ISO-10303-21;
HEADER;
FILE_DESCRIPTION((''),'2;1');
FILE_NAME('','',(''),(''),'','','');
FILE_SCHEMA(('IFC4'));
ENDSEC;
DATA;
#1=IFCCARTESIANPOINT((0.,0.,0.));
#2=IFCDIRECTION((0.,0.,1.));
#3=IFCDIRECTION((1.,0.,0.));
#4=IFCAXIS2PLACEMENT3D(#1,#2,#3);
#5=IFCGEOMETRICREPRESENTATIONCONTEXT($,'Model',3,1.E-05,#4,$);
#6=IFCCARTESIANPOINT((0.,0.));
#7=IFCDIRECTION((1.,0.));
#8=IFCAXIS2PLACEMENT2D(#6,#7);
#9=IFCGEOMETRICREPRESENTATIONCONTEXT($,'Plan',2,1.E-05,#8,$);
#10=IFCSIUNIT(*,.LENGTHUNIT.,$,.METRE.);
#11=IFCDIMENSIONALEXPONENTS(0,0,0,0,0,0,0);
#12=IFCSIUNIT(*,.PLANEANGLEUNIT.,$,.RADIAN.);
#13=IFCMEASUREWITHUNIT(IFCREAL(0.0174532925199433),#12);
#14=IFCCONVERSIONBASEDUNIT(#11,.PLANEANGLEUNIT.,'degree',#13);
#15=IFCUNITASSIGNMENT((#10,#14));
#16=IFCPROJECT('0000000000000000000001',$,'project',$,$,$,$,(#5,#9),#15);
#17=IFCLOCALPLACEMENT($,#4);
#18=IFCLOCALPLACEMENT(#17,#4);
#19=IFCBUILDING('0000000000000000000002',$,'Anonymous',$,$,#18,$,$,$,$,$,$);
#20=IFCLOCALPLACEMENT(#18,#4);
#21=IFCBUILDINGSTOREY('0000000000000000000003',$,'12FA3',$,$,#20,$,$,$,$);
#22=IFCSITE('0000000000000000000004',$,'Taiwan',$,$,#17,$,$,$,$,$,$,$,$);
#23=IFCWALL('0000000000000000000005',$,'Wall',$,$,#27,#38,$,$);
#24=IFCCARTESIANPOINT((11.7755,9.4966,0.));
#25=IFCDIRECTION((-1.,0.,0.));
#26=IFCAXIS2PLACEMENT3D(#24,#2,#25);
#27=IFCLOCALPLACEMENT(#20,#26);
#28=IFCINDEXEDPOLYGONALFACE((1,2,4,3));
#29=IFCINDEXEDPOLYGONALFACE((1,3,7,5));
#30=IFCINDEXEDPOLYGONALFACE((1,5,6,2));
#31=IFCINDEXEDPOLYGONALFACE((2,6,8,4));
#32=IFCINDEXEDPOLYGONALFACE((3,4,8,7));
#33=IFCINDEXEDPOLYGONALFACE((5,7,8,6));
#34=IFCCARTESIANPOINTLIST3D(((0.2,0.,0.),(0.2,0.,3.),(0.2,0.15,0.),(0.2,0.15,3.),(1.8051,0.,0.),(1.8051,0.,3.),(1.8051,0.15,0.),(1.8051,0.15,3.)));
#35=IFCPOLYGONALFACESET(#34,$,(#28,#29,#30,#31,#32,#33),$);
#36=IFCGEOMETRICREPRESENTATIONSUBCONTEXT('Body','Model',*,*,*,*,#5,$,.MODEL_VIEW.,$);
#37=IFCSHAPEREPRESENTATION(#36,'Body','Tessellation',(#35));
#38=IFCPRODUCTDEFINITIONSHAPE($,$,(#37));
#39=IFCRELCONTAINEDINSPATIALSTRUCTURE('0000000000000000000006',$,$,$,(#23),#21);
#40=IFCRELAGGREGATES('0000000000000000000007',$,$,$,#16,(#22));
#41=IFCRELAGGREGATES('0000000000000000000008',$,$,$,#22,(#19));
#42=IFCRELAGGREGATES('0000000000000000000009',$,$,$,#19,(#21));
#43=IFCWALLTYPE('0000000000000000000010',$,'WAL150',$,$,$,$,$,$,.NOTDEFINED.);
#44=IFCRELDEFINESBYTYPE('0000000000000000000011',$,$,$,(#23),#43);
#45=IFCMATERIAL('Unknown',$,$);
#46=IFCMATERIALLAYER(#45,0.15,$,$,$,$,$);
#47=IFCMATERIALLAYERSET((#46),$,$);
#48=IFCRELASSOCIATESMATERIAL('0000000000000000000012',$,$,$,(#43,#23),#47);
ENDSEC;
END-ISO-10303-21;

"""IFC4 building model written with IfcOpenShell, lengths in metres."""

from ifc_helpers import new_model, entity, si_unit, converted_unit, frame, origin_with_axes, origin_2d_with_axis, place, context, subcontext, project, spatial, line, indexed_curve, outline, extrude, material, layer, layer_set, layer_usage, type_object, element, save


model = new_model("IFC4")

# Units and contexts
model_context = context("Model", 3, precision=1e-05, world=origin_with_axes())
plan_context = context("Plan", 2, precision=1e-05, world=origin_2d_with_axis())
body_context_1 = subcontext(model_context, "Body", "Model", "MODEL_VIEW")
ifc_project = project(units=[si_unit("LENGTHUNIT", "METRE"), converted_unit("PLANEANGLEUNIT", "degree", entity("IfcReal", 0.0174532925199433), si_unit("PLANEANGLEUNIT", "RADIAN"), dimensions=[0, 0, 0, 0, 0, 0, 0])], contexts=[model_context, plan_context])

# Site, building, storey
site_placement = place(None, origin_with_axes())
site = spatial("IfcSite", under=ifc_project, at=site_placement, Name="Taiwan")
building_placement = place(site_placement, origin_with_axes())
building = spatial("IfcBuilding", under=site, at=building_placement, Name="Anonymous")
storey_placement = place(building_placement, origin_with_axes())
storey = spatial("IfcBuildingStorey", under=building, at=storey_placement, Name="12FA3")

# Shared definitions
ifc_material = material(Name="Unknown")

# Wall
ifc_layer_1 = layer(ifc_material, 0.15)
ifc_layer_set_1 = layer_set([ifc_layer_1])
ifc_layer_usage_1 = layer_usage(ifc_layer_set_1, "AXIS2", "POSITIVE", 0.0)
wall_type_1 = type_object("IfcWallType", Name="WAL150", PredefinedType="NOTDEFINED", material=ifc_layer_set_1)
wall_1_placement = place(storey_placement, frame((11.7755, 9.4966, 0.0), z_axis=(0.0, 0.0, 1.0), x_axis=(-1.0, 0.0, 0.0)))
element("IfcWall", 1, at=wall_1_placement, inside=storey, type_object=wall_type_1, material=ifc_layer_usage_1, Name="Wall", context=body_context_1, shape_type="SweptSolid", body=[
    extrude(outline(indexed_curve([(0.2, 0.0), (0.2, 0.15), (1.8051, 0.15), (1.8051, 0.0)], segments=[line(1, 2, 3, 4, 1)])), origin_with_axes(), (0.0, 0.0, 1.0), 3.0),
])

save(model, "model.ifc")
